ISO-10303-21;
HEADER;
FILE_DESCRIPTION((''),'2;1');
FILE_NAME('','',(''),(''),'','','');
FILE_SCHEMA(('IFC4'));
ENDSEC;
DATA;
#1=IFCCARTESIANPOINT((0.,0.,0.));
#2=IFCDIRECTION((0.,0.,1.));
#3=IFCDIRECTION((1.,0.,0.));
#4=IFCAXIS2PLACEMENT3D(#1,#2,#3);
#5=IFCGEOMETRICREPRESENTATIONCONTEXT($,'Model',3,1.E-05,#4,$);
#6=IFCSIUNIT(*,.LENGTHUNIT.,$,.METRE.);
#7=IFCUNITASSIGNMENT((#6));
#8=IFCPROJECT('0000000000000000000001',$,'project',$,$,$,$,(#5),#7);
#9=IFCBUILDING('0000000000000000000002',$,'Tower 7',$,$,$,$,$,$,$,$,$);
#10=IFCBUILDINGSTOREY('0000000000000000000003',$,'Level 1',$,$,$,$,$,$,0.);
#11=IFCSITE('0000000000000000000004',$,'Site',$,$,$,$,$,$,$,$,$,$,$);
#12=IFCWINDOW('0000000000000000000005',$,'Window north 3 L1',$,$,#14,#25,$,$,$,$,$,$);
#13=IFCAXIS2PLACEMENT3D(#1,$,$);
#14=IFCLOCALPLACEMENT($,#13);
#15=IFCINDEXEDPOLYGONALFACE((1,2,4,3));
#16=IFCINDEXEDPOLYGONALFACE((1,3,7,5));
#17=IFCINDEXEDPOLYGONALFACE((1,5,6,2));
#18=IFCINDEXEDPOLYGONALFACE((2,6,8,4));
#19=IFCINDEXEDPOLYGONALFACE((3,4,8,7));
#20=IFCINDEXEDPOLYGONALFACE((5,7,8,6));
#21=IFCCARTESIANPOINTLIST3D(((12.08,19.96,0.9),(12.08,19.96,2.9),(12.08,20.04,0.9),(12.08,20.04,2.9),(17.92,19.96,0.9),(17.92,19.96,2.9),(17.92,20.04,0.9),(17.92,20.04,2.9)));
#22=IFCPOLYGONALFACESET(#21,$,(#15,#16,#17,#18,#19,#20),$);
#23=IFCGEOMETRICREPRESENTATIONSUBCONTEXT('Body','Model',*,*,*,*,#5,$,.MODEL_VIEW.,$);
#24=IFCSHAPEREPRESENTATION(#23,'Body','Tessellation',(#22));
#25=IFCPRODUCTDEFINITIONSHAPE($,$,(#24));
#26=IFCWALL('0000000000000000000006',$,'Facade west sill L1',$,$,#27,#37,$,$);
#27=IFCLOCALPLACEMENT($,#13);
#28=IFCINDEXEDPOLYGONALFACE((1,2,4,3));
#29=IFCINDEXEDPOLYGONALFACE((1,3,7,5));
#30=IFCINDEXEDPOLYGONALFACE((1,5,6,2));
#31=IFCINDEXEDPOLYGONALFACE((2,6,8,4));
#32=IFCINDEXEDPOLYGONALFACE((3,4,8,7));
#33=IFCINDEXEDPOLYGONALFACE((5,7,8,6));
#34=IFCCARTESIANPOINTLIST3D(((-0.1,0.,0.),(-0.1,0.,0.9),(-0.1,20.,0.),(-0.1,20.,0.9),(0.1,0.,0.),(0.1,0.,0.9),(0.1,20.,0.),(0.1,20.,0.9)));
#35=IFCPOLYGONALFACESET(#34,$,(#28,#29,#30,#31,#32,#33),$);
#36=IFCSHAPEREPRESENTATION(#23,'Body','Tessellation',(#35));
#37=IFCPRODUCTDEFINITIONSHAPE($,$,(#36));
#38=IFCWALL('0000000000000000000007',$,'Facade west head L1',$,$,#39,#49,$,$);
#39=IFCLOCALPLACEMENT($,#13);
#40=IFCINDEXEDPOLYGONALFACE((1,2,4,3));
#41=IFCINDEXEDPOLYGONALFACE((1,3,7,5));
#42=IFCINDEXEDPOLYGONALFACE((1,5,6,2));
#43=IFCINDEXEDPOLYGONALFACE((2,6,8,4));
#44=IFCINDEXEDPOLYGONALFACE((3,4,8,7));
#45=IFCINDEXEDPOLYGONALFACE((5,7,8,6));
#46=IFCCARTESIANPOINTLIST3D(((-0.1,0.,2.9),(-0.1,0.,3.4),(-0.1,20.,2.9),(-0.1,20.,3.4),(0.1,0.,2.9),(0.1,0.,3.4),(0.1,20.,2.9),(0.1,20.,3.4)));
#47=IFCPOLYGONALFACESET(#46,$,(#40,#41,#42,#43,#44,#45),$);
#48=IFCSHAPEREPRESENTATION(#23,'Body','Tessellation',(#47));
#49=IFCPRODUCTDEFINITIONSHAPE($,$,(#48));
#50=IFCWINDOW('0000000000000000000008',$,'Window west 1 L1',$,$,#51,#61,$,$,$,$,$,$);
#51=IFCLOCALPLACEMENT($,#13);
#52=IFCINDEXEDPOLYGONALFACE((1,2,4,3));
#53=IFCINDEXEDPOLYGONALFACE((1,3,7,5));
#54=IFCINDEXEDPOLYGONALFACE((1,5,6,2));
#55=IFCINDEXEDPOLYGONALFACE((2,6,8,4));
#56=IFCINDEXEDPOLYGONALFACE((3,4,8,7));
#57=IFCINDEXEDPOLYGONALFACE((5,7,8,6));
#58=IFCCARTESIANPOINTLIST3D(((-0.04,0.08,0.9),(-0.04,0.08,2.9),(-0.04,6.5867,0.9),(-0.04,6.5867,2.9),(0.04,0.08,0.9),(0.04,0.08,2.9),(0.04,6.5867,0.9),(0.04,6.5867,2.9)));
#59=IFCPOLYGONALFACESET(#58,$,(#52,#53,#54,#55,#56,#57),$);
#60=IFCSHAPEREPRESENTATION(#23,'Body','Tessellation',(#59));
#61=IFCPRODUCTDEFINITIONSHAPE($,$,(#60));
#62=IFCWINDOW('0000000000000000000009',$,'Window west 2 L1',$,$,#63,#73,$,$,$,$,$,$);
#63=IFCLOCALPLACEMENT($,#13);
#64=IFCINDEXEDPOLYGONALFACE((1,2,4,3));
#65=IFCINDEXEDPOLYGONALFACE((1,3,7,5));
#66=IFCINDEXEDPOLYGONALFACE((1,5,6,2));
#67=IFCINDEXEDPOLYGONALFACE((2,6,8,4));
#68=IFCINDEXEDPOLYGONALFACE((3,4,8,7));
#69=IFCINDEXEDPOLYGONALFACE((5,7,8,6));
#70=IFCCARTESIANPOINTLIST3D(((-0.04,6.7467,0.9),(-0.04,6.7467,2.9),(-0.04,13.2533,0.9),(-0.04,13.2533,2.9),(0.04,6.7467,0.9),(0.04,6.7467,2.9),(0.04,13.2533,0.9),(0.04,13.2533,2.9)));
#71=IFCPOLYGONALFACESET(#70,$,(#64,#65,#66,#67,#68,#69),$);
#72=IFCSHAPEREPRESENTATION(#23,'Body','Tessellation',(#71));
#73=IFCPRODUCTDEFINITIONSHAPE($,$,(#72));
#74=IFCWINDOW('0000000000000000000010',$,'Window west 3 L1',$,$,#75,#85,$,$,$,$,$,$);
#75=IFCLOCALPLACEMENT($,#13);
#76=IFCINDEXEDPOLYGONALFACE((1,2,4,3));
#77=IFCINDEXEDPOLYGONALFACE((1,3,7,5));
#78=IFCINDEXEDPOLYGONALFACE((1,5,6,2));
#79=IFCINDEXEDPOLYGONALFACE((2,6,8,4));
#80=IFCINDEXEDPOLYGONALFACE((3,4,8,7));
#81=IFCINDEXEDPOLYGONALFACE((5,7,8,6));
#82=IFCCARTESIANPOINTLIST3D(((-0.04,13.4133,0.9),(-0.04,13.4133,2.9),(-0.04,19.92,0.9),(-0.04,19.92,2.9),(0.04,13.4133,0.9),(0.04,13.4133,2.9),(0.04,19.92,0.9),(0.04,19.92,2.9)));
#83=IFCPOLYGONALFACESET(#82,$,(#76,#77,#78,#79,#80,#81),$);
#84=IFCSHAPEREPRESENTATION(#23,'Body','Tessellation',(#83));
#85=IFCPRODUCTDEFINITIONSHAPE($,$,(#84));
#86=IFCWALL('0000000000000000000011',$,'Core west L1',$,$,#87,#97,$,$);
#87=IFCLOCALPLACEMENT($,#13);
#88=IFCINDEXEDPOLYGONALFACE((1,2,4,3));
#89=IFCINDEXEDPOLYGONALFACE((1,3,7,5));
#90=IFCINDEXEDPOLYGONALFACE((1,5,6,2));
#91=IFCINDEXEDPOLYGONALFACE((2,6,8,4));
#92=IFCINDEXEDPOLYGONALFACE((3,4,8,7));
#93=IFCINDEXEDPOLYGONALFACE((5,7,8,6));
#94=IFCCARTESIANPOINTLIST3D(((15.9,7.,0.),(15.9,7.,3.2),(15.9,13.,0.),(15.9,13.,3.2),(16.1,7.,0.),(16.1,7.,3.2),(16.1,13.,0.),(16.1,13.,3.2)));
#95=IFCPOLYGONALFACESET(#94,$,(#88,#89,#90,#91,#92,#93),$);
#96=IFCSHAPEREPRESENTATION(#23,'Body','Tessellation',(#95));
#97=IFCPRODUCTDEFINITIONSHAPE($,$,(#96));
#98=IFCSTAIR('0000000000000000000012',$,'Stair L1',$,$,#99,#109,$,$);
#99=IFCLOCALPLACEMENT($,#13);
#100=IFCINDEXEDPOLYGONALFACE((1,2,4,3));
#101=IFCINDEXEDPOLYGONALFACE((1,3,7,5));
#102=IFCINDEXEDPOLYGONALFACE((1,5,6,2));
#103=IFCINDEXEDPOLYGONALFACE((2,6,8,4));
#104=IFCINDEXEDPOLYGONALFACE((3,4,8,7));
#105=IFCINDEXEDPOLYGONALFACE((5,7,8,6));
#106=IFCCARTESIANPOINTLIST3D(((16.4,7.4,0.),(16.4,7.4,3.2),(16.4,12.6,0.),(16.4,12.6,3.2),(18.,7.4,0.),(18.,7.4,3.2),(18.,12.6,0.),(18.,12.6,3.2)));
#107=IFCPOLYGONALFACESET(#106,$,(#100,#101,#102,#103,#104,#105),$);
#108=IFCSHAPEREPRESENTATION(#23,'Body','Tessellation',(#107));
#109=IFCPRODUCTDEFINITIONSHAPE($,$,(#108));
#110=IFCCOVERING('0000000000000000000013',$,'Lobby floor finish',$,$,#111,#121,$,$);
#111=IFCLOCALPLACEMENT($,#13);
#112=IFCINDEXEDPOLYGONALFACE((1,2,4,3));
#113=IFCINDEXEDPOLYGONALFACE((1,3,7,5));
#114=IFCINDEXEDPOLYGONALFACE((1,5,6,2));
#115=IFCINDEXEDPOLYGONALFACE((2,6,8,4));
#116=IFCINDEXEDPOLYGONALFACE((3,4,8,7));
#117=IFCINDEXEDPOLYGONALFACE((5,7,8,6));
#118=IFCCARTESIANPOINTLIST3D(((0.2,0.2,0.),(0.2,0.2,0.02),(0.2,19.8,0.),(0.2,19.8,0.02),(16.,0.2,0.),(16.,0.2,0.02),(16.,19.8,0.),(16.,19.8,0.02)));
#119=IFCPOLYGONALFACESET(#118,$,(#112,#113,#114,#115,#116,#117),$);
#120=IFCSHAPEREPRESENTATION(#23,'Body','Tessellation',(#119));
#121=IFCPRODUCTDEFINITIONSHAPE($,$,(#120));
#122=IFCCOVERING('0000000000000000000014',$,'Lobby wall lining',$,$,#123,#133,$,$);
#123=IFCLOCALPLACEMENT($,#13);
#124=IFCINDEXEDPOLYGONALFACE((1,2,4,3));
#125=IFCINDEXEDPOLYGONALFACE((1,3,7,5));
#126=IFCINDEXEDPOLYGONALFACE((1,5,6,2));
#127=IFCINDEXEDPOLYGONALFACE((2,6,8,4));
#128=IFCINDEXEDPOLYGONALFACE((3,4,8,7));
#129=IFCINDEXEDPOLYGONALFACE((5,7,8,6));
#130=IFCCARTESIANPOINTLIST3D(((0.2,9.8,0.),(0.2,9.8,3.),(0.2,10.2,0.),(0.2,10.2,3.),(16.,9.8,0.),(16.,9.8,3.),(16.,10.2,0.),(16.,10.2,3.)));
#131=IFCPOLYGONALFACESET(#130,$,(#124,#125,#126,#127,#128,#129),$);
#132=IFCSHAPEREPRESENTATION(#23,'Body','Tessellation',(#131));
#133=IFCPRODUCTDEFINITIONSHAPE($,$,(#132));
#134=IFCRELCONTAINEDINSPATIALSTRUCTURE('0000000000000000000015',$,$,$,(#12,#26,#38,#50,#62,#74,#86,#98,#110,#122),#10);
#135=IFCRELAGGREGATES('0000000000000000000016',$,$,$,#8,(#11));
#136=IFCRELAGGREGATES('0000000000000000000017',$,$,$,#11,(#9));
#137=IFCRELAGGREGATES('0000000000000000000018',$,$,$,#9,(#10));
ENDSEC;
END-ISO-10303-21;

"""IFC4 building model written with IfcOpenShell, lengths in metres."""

from ifc_helpers import new_model, si_unit, frame, origin, origin_with_axes, origin_2d, place, context, subcontext, project, spatial, rectangle, extrude, element, save


model = new_model("IFC4")

# Units and contexts
model_context = context("Model", 3, precision=1e-05, world=origin_with_axes())
body_context = subcontext(model_context, "Body", "Model", "MODEL_VIEW")
ifc_project = project(units=[si_unit("LENGTHUNIT", "METRE")], contexts=[model_context])

# Site, building, storey
site = spatial("IfcSite", under=ifc_project, Name="Site")
building = spatial("IfcBuilding", under=site, Name="Tower 7")
storey = spatial("IfcBuildingStorey", under=building, Name="Level 1", Elevation=0.0)

# Window
window_1_placement = place(None, frame((15.0, 20.0, 0.9), z_axis=(0.0, 0.0, 1.0), x_axis=(1.0, 0.0, 0.0)))
element("IfcWindow", 1, at=window_1_placement, inside=storey, Name="Window north 3 L1", context=body_context, shape_type="SweptSolid", body=[
    extrude(rectangle(XDim=5.84, YDim=0.08, at=origin_2d()), origin(), (0.0, 0.0, 1.0), 2.0),
])

# Walls
wall_1_placement = place(None, frame((0.0, 10.0, 0.0), z_axis=(0.0, 0.0, 1.0), x_axis=(1.0, 0.0, 0.0)))
element("IfcWall", 2, at=wall_1_placement, inside=storey, Name="Facade west sill L1", context=body_context, shape_type="SweptSolid", body=[
    extrude(rectangle(XDim=0.2, YDim=20.0, at=origin_2d()), origin(), (0.0, 0.0, 1.0), 0.9),
])
wall_2_placement = place(None, frame((0.0, 10.0, 2.9), z_axis=(0.0, 0.0, 1.0), x_axis=(1.0, 0.0, 0.0)))
element("IfcWall", 3, at=wall_2_placement, inside=storey, Name="Facade west head L1", context=body_context, shape_type="SweptSolid", body=[
    extrude(rectangle(XDim=0.2, YDim=20.0, at=origin_2d()), origin(), (0.0, 0.0, 1.0), 0.5),
])

# Windows
for number, where, z_axis, x_axis, name in (
    (4, (0.0, 3.3333, 0.9), (0.0, 0.0, 1.0), (1.0, 0.0, 0.0), "Window west 1 L1"),
    (5, (0.0, 10.0, 0.9), (0.0, 0.0, 1.0), (1.0, 0.0, 0.0), "Window west 2 L1"),
):
    element("IfcWindow", number, at=place(None, frame(where, z_axis=z_axis, x_axis=x_axis)), inside=storey, Name=name, context=body_context, shape_type="SweptSolid", body=[
        extrude(rectangle(XDim=0.08, YDim=6.5067, at=origin_2d()), origin(), (0.0, 0.0, 1.0), 2.0),
    ])
window_2_placement = place(None, frame((0.0, 16.6667, 0.9), z_axis=(0.0, 0.0, 1.0), x_axis=(1.0, 0.0, 0.0)))
element("IfcWindow", 6, at=window_2_placement, inside=storey, Name="Window west 3 L1", context=body_context, shape_type="SweptSolid", body=[
    extrude(rectangle(XDim=0.08, YDim=6.5067, at=origin_2d()), origin(), (0.0, 0.0, 1.0), 2.0),
])

# Wall
wall_3_placement = place(None, frame((16.0, 10.0, 0.0), z_axis=(0.0, 0.0, 1.0), x_axis=(1.0, 0.0, 0.0)))
element("IfcWall", 7, at=wall_3_placement, inside=storey, Name="Core west L1", context=body_context, shape_type="SweptSolid", body=[
    extrude(rectangle(XDim=0.2, YDim=6.0, at=origin_2d()), origin(), (0.0, 0.0, 1.0), 3.2),
])

# Stair
stair_placement = place(None, frame((17.2, 10.0, 0.0), z_axis=(0.0, 0.0, 1.0), x_axis=(1.0, 0.0, 0.0)))
element("IfcStair", 8, at=stair_placement, inside=storey, Name="Stair L1", context=body_context, shape_type="SweptSolid", body=[
    extrude(rectangle(XDim=1.6, YDim=5.2, at=origin_2d()), origin(), (0.0, 0.0, 1.0), 3.2),
])

# Coverings
covering_1_placement = place(None, frame((8.1, 10.0, 0.0), z_axis=(0.0, 0.0, 1.0), x_axis=(1.0, 0.0, 0.0)))
element("IfcCovering", 9, at=covering_1_placement, inside=storey, Name="Lobby floor finish", context=body_context, shape_type="SweptSolid", body=[
    extrude(rectangle(XDim=15.8, YDim=19.6, at=origin_2d()), origin(), (0.0, 0.0, 1.0), 0.02),
])
covering_2_placement = place(None, frame((8.1, 10.0, 0.0), z_axis=(0.0, 0.0, 1.0), x_axis=(1.0, 0.0, 0.0)))
element("IfcCovering", 10, at=covering_2_placement, inside=storey, Name="Lobby wall lining", context=body_context, shape_type="SweptSolid", body=[
    extrude(rectangle(XDim=15.8, YDim=0.4, at=origin_2d()), origin(), (0.0, 0.0, 1.0), 3.0),
])

save(model, "model.ifc")
